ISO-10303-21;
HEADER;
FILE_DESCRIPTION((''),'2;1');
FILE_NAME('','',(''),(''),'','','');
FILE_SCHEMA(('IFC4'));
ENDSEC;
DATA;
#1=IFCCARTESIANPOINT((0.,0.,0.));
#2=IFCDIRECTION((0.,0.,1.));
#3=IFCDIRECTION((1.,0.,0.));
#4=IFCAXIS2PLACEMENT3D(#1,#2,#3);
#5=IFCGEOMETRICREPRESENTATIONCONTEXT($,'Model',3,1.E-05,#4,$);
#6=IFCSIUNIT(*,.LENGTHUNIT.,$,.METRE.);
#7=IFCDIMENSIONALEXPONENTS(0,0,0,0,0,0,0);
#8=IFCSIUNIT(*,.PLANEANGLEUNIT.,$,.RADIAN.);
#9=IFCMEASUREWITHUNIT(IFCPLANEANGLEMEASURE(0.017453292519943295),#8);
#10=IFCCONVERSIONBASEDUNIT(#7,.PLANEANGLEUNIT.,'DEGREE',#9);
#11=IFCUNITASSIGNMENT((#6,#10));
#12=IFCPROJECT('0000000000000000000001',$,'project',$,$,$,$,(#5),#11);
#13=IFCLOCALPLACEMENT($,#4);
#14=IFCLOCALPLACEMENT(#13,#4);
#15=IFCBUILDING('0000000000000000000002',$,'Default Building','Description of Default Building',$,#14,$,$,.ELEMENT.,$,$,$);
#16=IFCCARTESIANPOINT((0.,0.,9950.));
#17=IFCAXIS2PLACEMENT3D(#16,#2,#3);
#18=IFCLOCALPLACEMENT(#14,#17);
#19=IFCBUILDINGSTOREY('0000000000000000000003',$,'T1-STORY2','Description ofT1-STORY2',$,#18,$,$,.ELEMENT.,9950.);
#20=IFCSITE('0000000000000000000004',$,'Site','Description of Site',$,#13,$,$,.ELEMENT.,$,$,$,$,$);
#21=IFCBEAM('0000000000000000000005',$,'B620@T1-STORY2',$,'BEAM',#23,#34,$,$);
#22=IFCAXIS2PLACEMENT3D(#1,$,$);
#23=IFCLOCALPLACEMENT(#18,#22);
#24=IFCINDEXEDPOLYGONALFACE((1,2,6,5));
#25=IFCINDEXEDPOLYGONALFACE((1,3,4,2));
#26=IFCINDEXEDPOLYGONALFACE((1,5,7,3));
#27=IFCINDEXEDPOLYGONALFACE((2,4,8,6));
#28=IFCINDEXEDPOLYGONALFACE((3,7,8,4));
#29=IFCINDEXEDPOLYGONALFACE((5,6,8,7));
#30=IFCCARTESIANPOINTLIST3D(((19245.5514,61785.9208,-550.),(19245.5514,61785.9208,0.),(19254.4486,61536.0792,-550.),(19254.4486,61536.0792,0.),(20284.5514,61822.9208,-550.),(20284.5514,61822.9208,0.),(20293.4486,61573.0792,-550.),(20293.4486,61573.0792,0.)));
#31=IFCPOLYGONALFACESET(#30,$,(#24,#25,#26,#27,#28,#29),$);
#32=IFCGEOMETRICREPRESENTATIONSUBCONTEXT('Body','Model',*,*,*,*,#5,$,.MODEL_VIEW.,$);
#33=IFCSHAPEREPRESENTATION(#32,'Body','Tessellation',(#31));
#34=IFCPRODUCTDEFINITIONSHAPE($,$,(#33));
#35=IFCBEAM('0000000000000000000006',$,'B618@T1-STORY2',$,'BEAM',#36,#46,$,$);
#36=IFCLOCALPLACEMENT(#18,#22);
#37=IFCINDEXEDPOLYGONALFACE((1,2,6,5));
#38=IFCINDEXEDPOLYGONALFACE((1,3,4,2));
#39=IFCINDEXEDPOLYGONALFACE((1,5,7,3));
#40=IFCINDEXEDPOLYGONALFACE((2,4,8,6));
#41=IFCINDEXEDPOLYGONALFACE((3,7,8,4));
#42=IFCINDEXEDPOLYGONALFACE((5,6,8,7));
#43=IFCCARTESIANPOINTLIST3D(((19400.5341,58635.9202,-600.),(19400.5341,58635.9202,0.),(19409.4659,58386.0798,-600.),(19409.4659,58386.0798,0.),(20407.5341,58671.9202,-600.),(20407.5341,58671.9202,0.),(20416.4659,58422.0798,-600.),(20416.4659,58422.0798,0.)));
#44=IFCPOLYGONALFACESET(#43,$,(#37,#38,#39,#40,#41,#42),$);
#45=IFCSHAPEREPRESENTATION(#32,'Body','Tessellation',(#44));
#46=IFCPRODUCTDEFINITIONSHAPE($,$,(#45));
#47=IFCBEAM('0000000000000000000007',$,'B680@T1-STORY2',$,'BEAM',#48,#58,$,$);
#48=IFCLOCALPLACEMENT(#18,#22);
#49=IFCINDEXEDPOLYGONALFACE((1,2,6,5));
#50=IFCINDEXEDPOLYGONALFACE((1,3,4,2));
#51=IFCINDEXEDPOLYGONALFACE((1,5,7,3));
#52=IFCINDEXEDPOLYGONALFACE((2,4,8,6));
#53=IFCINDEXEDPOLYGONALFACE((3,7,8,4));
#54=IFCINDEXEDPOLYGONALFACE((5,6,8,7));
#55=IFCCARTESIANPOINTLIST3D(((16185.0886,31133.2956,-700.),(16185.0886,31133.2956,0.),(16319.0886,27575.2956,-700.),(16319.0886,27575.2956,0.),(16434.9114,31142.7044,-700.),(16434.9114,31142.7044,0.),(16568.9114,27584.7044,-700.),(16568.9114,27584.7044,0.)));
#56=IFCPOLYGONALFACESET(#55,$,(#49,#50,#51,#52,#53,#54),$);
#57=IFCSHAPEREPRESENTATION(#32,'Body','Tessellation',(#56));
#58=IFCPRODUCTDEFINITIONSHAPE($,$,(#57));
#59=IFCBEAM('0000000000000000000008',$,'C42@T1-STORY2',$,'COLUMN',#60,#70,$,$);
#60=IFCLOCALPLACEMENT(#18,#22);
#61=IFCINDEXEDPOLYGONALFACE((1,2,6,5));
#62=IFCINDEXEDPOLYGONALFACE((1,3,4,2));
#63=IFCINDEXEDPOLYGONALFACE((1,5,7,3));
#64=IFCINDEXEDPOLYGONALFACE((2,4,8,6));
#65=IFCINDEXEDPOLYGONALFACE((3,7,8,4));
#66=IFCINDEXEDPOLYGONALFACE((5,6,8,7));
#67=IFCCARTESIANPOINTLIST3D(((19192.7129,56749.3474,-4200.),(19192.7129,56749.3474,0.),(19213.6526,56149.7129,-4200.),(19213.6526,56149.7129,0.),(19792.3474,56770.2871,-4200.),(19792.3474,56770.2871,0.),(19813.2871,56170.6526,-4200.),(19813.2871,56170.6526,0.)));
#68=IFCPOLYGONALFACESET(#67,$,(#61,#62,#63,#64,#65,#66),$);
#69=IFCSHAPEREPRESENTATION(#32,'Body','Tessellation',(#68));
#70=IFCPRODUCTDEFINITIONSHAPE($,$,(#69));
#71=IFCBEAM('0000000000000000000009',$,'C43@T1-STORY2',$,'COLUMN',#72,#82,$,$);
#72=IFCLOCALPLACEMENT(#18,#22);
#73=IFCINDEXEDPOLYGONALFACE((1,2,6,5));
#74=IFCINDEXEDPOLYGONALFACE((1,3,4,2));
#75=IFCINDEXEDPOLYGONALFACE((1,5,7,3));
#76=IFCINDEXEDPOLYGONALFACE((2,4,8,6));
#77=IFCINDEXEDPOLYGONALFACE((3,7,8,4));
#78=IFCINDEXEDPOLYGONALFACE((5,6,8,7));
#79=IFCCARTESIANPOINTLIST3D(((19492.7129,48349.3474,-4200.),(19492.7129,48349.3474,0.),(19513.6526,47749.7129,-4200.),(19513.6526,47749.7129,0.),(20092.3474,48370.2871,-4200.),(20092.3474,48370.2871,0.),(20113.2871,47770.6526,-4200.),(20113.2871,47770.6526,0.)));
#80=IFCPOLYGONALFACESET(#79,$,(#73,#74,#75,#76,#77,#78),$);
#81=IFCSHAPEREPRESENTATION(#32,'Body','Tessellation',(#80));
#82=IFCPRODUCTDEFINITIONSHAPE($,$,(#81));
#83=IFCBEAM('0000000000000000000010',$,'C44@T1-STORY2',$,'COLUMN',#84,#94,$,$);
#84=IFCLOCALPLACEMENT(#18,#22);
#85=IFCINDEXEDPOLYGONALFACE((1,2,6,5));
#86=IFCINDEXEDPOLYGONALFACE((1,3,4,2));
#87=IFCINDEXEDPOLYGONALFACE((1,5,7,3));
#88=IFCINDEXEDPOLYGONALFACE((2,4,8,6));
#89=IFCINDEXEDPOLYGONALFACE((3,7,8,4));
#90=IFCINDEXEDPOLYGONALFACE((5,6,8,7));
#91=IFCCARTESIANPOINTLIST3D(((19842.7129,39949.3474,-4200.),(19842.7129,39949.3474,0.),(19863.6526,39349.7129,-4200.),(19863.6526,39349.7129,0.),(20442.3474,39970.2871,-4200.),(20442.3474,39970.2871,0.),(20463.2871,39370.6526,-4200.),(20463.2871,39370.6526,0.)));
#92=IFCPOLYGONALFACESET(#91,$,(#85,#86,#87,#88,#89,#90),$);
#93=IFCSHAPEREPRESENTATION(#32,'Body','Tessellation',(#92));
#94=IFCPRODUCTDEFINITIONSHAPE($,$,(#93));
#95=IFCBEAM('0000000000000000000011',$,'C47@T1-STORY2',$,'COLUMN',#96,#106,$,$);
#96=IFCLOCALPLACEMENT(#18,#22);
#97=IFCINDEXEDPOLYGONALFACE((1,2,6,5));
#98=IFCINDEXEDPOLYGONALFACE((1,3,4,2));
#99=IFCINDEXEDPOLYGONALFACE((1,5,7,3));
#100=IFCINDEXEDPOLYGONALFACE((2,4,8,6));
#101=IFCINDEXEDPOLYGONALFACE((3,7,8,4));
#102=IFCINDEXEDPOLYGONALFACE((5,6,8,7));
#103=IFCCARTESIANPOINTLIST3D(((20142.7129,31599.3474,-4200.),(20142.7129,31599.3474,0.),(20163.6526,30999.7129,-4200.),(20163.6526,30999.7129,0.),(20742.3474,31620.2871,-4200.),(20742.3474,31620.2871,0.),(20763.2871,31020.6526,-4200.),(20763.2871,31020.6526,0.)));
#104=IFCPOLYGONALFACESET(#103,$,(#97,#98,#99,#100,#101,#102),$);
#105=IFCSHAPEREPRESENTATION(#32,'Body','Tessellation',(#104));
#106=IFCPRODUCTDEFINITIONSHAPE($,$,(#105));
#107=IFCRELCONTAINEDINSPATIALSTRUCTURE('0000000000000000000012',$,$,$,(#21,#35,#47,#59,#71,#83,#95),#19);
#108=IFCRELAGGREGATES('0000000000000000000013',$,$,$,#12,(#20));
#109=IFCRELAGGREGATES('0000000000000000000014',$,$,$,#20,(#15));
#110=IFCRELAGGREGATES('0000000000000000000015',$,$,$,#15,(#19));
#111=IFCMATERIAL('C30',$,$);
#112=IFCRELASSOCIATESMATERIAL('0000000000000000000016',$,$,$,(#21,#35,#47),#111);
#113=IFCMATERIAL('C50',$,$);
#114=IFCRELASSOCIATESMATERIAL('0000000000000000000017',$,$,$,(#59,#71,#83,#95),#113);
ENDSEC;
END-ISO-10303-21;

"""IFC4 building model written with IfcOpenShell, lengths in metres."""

from ifc_helpers import new_model, entity, si_unit, converted_unit, frame, origin_with_axes, place, context, subcontext, project, spatial, rectangle, extrude, material, element, save


model = new_model("IFC4")

# Units and contexts
model_context = context("Model", 3, precision=1e-05, world=origin_with_axes())
body_context = subcontext(model_context, "Body", "Model", "MODEL_VIEW")
ifc_project = project(units=[si_unit("LENGTHUNIT", "METRE"), converted_unit("PLANEANGLEUNIT", "DEGREE", entity("IfcPlaneAngleMeasure", 0.017453292519943295), si_unit("PLANEANGLEUNIT", "RADIAN"), dimensions=[0, 0, 0, 0, 0, 0, 0])], contexts=[model_context])

# Site, building, storey
site_placement = place(None, origin_with_axes())
site = spatial("IfcSite", under=ifc_project, at=site_placement, Name="Site", Description="Description of Site", CompositionType="ELEMENT")
building_placement = place(site_placement, origin_with_axes())
building = spatial("IfcBuilding", under=site, at=building_placement, Name="Default Building", Description="Description of Default Building", CompositionType="ELEMENT")
storey_placement = place(building_placement, frame((0.0, 0.0, 9950.0), z_axis=(0.0, 0.0, 1.0), x_axis=(1.0, 0.0, 0.0)))
storey = spatial("IfcBuildingStorey", under=building, at=storey_placement, Name="T1-STORY2", Description="Description ofT1-STORY2", CompositionType="ELEMENT", Elevation=9950.0)

# Beams
ifc_material_1 = material(Name="C30")
beam_1_placement = place(storey_placement, frame((19250.0, 61661.0, -275.0), z_axis=(0.999367, 0.035589, 0.0), x_axis=(-0.035589, 0.999367, 0.0)))
element("IfcBeam", 1, at=beam_1_placement, inside=storey, material=ifc_material_1, Name="B620@T1-STORY2", ObjectType="BEAM", context=body_context, shape_type="SweptSolid", body=[
    extrude(rectangle(XDim=250.0, YDim=550.0), origin_with_axes(), (0.0, 0.0, 1.0), 1039.6586),
])
beam_2_placement = place(storey_placement, frame((19405.0, 58511.0, -300.0), z_axis=(0.999362, 0.035727, 0.0), x_axis=(-0.035727, 0.999362, 0.0)))
element("IfcBeam", 2, at=beam_2_placement, inside=storey, material=ifc_material_1, Name="B618@T1-STORY2", ObjectType="BEAM", context=body_context, shape_type="SweptSolid", body=[
    extrude(rectangle(XDim=250.0, YDim=600.0), origin_with_axes(), (0.0, 0.0, 1.0), 1007.6433),
])
beam_3_placement = place(storey_placement, frame((16310.0, 31138.0, -350.0), z_axis=(0.037635, -0.999292, 0.0), x_axis=(0.999292, 0.037635, 0.0)))
element("IfcBeam", 3, at=beam_3_placement, inside=storey, material=ifc_material_1, Name="B680@T1-STORY2", ObjectType="BEAM", context=body_context, shape_type="SweptSolid", body=[
    extrude(rectangle(XDim=250.0, YDim=700.0), origin_with_axes(), (0.0, 0.0, 1.0), 3560.5224),
])
ifc_material_2 = material(Name="C50")
for number, where, z_axis, x_axis, name in (
    (4, (19503.0, 56460.0, -4200.0), (0.0, 0.0, 1.0), (-0.999391, -0.034899, 0.0), "C42@T1-STORY2"),
    (5, (19803.0, 48060.0, -4200.0), (0.0, 0.0, 1.0), (-0.999391, -0.034899, 0.0), "C43@T1-STORY2"),
    (6, (20153.0, 39660.0, -4200.0), (0.0, 0.0, 1.0), (-0.999391, -0.034899, 0.0), "C44@T1-STORY2"),
    (7, (20453.0, 31310.0, -4200.0), (0.0, 0.0, 1.0), (-0.999391, -0.034899, 0.0), "C47@T1-STORY2"),
):
    element("IfcBeam", number, at=place(storey_placement, frame(where, z_axis=z_axis, x_axis=x_axis)), inside=storey, material=ifc_material_2, Name=name, ObjectType="COLUMN", context=body_context, shape_type="SweptSolid", body=[
        extrude(rectangle(XDim=600.0, YDim=600.0), origin_with_axes(), (0.0, 0.0, 1.0), 4200.0),
    ])

save(model, "model.ifc")
